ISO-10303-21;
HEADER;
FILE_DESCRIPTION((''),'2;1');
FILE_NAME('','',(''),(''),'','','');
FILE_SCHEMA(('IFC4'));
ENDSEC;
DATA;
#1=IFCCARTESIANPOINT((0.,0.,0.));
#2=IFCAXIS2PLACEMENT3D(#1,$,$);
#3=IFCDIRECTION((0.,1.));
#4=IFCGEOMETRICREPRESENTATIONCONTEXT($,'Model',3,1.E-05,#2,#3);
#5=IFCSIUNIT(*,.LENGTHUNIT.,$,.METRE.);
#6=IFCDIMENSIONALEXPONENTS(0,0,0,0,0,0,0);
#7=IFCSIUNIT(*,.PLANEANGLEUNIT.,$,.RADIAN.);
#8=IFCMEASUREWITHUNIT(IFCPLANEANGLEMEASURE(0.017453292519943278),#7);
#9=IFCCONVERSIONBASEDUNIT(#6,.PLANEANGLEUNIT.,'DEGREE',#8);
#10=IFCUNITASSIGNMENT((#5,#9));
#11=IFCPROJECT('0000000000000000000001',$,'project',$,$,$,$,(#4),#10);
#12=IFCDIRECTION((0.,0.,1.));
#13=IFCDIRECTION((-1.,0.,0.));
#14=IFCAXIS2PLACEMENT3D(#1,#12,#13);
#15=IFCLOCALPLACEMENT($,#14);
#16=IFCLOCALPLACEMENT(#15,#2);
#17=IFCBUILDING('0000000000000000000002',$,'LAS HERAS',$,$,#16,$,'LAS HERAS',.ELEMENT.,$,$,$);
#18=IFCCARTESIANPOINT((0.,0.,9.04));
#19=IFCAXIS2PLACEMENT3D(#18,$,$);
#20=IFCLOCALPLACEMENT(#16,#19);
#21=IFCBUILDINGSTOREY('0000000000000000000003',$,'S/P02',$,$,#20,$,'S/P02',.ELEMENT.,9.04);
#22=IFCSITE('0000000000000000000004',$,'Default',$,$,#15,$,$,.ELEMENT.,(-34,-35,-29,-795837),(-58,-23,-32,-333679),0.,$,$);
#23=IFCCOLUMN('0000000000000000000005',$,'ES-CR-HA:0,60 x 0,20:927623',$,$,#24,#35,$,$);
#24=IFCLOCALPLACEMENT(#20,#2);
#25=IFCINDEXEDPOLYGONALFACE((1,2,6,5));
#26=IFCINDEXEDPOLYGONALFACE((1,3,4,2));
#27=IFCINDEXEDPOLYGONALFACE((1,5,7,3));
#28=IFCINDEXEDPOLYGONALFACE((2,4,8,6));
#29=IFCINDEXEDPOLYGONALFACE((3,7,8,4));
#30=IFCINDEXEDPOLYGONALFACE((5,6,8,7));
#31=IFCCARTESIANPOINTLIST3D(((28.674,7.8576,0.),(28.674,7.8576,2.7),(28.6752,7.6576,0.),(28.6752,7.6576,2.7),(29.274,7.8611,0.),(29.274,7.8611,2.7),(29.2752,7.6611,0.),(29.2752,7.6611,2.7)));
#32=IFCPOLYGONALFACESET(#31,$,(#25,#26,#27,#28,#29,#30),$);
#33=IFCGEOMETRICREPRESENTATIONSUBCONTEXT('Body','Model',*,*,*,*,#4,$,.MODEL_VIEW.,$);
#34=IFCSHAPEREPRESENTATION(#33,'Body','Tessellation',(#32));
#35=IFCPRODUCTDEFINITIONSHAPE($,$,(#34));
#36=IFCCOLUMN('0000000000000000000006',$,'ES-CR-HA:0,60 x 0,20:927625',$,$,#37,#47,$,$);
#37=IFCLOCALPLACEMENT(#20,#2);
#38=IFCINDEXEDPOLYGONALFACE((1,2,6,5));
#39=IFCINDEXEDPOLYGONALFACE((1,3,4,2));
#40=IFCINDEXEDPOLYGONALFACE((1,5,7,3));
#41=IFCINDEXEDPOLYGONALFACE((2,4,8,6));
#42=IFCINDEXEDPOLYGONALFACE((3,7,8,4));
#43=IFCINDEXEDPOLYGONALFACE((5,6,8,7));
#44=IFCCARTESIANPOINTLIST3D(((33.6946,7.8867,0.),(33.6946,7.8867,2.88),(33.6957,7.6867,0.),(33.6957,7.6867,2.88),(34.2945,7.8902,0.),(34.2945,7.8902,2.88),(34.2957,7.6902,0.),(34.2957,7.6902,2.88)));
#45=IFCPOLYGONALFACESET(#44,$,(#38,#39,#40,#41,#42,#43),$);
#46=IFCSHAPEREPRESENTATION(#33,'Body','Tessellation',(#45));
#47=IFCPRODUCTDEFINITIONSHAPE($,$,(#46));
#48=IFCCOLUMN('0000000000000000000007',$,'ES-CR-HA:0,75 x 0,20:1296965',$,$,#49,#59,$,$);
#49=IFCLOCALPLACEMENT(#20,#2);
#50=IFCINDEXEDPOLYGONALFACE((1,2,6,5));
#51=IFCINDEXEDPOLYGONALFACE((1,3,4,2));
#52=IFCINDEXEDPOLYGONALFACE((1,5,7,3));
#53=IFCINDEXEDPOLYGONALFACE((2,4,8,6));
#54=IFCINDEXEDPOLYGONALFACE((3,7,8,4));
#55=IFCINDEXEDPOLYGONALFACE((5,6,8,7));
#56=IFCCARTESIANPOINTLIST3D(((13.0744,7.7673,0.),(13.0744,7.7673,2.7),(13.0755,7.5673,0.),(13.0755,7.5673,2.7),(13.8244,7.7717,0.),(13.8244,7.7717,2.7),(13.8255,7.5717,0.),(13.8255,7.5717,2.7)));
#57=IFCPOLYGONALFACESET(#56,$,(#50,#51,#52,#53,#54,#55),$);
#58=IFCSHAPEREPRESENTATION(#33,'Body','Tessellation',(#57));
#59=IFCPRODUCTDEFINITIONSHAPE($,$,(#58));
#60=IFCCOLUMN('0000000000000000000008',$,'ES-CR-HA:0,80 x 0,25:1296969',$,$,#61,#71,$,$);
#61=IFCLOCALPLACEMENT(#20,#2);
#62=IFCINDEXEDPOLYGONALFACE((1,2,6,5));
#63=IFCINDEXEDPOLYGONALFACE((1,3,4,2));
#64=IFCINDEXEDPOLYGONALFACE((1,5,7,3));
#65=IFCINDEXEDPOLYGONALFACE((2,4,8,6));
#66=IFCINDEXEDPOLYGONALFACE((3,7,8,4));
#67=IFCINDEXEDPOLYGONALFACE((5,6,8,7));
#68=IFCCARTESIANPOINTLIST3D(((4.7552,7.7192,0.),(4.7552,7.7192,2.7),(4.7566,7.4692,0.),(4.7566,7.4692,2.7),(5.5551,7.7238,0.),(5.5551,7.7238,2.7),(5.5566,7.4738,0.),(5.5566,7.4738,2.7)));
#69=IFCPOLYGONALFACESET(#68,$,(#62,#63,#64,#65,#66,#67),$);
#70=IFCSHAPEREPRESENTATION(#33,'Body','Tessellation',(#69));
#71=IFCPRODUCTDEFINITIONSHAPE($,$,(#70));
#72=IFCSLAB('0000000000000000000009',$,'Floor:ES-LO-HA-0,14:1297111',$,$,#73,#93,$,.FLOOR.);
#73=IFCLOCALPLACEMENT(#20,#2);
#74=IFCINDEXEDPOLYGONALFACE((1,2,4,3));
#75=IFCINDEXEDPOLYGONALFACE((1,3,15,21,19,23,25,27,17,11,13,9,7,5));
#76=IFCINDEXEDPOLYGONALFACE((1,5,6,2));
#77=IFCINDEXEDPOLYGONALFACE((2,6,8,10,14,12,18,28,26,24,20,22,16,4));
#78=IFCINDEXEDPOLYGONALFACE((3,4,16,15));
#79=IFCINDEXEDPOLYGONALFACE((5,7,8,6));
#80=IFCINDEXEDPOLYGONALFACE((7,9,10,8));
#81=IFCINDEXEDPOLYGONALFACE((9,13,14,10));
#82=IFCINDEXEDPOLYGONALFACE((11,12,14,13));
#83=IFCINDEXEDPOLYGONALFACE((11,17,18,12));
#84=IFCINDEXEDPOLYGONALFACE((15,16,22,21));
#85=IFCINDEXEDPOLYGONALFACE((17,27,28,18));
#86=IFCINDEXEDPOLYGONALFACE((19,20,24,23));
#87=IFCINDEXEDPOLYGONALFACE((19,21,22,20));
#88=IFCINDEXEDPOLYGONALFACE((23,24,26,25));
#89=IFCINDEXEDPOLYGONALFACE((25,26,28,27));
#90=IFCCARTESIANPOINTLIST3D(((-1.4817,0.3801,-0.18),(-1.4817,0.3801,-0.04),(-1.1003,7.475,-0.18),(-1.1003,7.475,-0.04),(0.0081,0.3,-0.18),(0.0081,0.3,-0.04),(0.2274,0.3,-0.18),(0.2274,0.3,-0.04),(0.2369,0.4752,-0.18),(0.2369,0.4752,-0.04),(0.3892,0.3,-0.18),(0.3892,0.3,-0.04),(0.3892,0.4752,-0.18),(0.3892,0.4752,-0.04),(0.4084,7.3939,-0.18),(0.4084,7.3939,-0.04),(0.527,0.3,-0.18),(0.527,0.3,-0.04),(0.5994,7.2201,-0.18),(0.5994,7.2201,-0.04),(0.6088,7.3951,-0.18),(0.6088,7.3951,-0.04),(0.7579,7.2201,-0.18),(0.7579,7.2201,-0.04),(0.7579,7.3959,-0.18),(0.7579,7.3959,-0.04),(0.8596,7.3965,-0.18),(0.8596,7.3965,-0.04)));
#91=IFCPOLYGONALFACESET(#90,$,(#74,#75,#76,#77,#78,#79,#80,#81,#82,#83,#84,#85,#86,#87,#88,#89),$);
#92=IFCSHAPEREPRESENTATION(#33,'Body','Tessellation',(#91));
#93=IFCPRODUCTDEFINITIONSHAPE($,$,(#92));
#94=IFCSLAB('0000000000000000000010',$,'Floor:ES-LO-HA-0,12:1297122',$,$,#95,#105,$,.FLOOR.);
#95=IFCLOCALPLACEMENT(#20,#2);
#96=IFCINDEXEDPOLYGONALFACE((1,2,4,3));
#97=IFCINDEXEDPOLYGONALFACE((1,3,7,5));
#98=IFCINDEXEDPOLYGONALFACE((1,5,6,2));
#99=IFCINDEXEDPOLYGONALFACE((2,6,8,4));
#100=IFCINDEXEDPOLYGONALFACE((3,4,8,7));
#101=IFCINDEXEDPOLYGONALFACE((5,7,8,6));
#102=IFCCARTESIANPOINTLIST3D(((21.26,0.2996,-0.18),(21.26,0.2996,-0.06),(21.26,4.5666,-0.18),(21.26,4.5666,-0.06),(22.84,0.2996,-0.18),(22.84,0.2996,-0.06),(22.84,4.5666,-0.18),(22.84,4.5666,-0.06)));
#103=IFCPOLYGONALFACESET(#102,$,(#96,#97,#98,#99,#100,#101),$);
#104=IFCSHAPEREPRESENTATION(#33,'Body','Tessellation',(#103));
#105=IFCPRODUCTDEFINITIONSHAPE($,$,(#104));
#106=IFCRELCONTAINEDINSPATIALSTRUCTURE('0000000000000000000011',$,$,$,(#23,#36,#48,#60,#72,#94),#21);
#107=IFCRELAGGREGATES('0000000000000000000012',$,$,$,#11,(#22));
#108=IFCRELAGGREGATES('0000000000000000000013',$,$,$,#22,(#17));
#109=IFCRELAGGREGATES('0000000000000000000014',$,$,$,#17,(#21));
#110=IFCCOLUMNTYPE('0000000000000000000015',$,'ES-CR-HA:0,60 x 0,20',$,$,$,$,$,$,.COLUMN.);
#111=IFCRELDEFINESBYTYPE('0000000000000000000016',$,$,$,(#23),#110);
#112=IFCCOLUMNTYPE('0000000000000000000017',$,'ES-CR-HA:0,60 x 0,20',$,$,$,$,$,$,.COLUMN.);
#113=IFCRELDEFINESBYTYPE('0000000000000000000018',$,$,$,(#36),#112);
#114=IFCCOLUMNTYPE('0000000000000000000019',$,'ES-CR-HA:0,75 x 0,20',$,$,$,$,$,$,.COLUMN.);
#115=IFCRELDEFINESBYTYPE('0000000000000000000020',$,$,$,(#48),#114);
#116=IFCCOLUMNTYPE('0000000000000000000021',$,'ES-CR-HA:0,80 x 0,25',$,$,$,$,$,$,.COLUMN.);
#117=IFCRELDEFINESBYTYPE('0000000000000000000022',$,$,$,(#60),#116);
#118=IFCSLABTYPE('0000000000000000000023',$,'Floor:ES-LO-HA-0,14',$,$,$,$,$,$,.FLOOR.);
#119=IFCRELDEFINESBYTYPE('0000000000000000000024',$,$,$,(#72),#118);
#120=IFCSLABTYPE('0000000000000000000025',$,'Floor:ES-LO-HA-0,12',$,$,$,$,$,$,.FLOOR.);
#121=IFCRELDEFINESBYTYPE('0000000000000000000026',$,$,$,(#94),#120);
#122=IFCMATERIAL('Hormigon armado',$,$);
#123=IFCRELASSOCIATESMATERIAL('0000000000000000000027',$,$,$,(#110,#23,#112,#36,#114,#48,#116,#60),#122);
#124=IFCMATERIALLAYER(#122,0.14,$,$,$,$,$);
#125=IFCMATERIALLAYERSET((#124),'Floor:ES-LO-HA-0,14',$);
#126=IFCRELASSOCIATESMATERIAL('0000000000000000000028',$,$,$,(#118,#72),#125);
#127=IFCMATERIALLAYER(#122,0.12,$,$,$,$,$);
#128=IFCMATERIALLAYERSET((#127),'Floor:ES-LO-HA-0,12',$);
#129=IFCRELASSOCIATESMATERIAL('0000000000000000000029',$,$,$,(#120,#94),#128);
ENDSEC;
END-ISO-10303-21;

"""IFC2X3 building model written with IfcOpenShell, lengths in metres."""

from ifc_helpers import new_model, entity, si_unit, converted_unit, direction, frame, frame_2d, origin, place, context, subcontext, project, spatial, polyline, rectangle, outline, extrude, source, transform, mapped, material, layer, layer_set, layer_usage, type_object, type_shapes, element, save


model = new_model("IFC2X3")

# Units and contexts
model_context = context("Model", 3, precision=1e-05, world=origin(), true_north=direction((0.0, 1.0)))
body_context = subcontext(model_context, "Body", "Model", "MODEL_VIEW")
ifc_project = project(units=[si_unit("LENGTHUNIT", "METRE"), converted_unit("PLANEANGLEUNIT", "DEGREE", entity("IfcPlaneAngleMeasure", 0.017453292519943278), si_unit("PLANEANGLEUNIT", "RADIAN"), dimensions=[0, 0, 0, 0, 0, 0, 0])], contexts=[model_context])

# Site, building, storey
site_placement = place(None, frame((0.0, 0.0, 0.0), z_axis=(0.0, 0.0, 1.0), x_axis=(-1.0, 0.0, 0.0)))
site = spatial("IfcSite", under=ifc_project, at=site_placement, Name="Default", CompositionType="ELEMENT", RefLatitude=(-34, -35, -29, -795837), RefLongitude=(-58, -23, -32, -333679), RefElevation=0.0)
building_placement = place(site_placement, origin())
building = spatial("IfcBuilding", under=site, at=building_placement, Name="LAS HERAS", LongName="LAS HERAS", CompositionType="ELEMENT")
storey_placement = place(building_placement, frame((0.0, 0.0, 9.04)))
storey = spatial("IfcBuildingStorey", under=building, at=storey_placement, Name="S/P02", LongName="S/P02", CompositionType="ELEMENT", Elevation=9.04)

# Columns
ifc_material = material(Name="Hormigon armado")
column_type_1 = type_object("IfcColumnType", Name="ES-CR-HA:0,60 x 0,20", PredefinedType="COLUMN", material=ifc_material)
shared_shape_1 = source(origin(), body_context, "Body", "SweptSolid", [
    extrude(rectangle(XDim=2.7, YDim=0.2, at=frame_2d((0.0, 0.0), x_axis=(1.0, 0.0))), frame((28.6746, 7.7576, 10.39), z_axis=(0.999983, 0.00576, 0.0), x_axis=(0.0, 0.0, 1.0)), (0.0, 0.0, 1.0), 0.6),
])
type_shapes(column_type_1, [shared_shape_1])
column_1_placement = place(storey_placement, frame((0.0, 0.0, -9.04)))
element("IfcColumn", 1, at=column_1_placement, inside=storey, type_object=column_type_1, material=ifc_material, Name="ES-CR-HA:0,60 x 0,20:927623", context=body_context, shape_type="MappedRepresentation", body=[
    mapped(shared_shape_1, transform((0.0, 0.0, 0.0), scale=1.0)),
])
column_type_2 = type_object("IfcColumnType", Name="ES-CR-HA:0,60 x 0,20", PredefinedType="COLUMN", material=ifc_material)
shared_shape_2 = source(origin(), body_context, "Body", "SweptSolid", [
    extrude(rectangle(XDim=0.6, YDim=0.2, at=frame_2d((0.0, 0.0), x_axis=(1.0, 0.0))), frame((33.9951, 7.7884, 9.04), z_axis=(0.0, 0.0, 1.0), x_axis=(-0.999983, -0.005788, 0.0)), (0.0, 0.0, 1.0), 2.88),
])
type_shapes(column_type_2, [shared_shape_2])
column_2_placement = place(storey_placement, frame((0.0, 0.0, -9.04)))
element("IfcColumn", 2, at=column_2_placement, inside=storey, type_object=column_type_2, material=ifc_material, Name="ES-CR-HA:0,60 x 0,20:927625", context=body_context, shape_type="MappedRepresentation", body=[
    mapped(shared_shape_2, transform((0.0, 0.0, 0.0), scale=1.0)),
])
column_type_3 = type_object("IfcColumnType", Name="ES-CR-HA:0,75 x 0,20", PredefinedType="COLUMN", material=ifc_material)
shared_shape_3 = source(origin(), body_context, "Body", "SweptSolid", [
    extrude(rectangle(XDim=0.75, YDim=0.2, at=frame_2d((0.0, 0.0), x_axis=(1.0, 0.0))), frame((13.4499, 7.6695, 9.04), z_axis=(0.0, 0.0, 1.0), x_axis=(-0.999983, -0.005788, 0.0)), (0.0, 0.0, 1.0), 2.7),
])
type_shapes(column_type_3, [shared_shape_3])
column_3_placement = place(storey_placement, frame((0.0, 0.0, -9.04)))
element("IfcColumn", 3, at=column_3_placement, inside=storey, type_object=column_type_3, material=ifc_material, Name="ES-CR-HA:0,75 x 0,20:1296965", context=body_context, shape_type="MappedRepresentation", body=[
    mapped(shared_shape_3, transform((0.0, 0.0, 0.0), scale=1.0)),
])
column_type_4 = type_object("IfcColumnType", Name="ES-CR-HA:0,80 x 0,25", PredefinedType="COLUMN", material=ifc_material)
shared_shape_4 = source(origin(), body_context, "Body", "SweptSolid", [
    extrude(rectangle(XDim=0.8, YDim=0.25, at=frame_2d((0.0, 0.0), x_axis=(1.0, 0.0))), frame((5.1559, 7.5965, 9.04), z_axis=(0.0, 0.0, 1.0), x_axis=(-0.999983, -0.005788, 0.0)), (0.0, 0.0, 1.0), 2.7),
])
type_shapes(column_type_4, [shared_shape_4])
column_4_placement = place(storey_placement, frame((0.0, 0.0, -9.04)))
element("IfcColumn", 4, at=column_4_placement, inside=storey, type_object=column_type_4, material=ifc_material, Name="ES-CR-HA:0,80 x 0,25:1296969", context=body_context, shape_type="MappedRepresentation", body=[
    mapped(shared_shape_4, transform((0.0, 0.0, 0.0), scale=1.0)),
])

# Slab, openings
ifc_layer_1 = layer(ifc_material, 0.14)
ifc_layer_set_1 = layer_set([ifc_layer_1], Name="Floor:ES-LO-HA-0,14")
ifc_layer_usage_1 = layer_usage(ifc_layer_set_1, "AXIS3", "POSITIVE", 0.0)
slab_type_1 = type_object("IfcSlabType", Name="Floor:ES-LO-HA-0,14", PredefinedType="FLOOR", material=ifc_layer_set_1)
slab_1_placement = place(storey_placement, origin())
slab_1 = element("IfcSlab", 5, at=slab_1_placement, inside=storey, type_object=slab_type_1, material=ifc_layer_usage_1, Name="Floor:ES-LO-HA-0,14:1297111", PredefinedType="FLOOR", context=body_context, shape_type="SweptSolid", body=[
    extrude(outline(polyline([(-0.2993, -3.5591), (-0.1615, -3.5591), (-0.1615, -3.3839), (-0.0091, -3.3839), (0.0003, -3.5591), (0.2196, -3.5591), (1.7094, -3.479), (1.328, 3.6159), (-0.1807, 3.5348), (-0.3811, 3.536), (-0.3717, 3.3611), (-0.5302, 3.3611), (-0.5302, 3.5368), (-0.6319, 3.5374), (-0.2993, -3.5591)])), frame((0.2277, 3.8591, -0.04), z_axis=(0.0, 0.0, -1.0), x_axis=(-1.0, 0.0, 0.0)), (0.0, 0.0, 1.0), 0.14),
])
opening_1_placement = place(slab_1_placement, origin())
element("IfcOpeningElement", 6, at=opening_1_placement, cuts=slab_1, ObjectType="Opening", context=body_context, shape_type="SweptSolid", body=[
    extrude(outline(polyline([(0.2369, 0.4752), (0.2274, 0.3), (0.3892, 0.3), (0.3892, 0.4752), (0.2369, 0.4752)])), frame((0.0, 0.0, -0.04)), (0.0, 0.0, -1.0), 0.14),
])
opening_2_placement = place(slab_1_placement, origin())
element("IfcOpeningElement", 7, at=opening_2_placement, cuts=slab_1, ObjectType="Opening", context=body_context, shape_type="SweptSolid", body=[
    extrude(outline(polyline([(0.7579, 7.2201), (0.7579, 7.3959), (0.6088, 7.3951), (0.5994, 7.2201), (0.7579, 7.2201)])), frame((0.0, 0.0, -0.04)), (0.0, 0.0, -1.0), 0.14),
])

# Slab
ifc_layer_2 = layer(ifc_material, 0.12)
ifc_layer_set_2 = layer_set([ifc_layer_2], Name="Floor:ES-LO-HA-0,12")
ifc_layer_usage_2 = layer_usage(ifc_layer_set_2, "AXIS3", "POSITIVE", 0.0)
slab_type_2 = type_object("IfcSlabType", Name="Floor:ES-LO-HA-0,12", PredefinedType="FLOOR", material=ifc_layer_set_2)
slab_2_placement = place(storey_placement, origin())
element("IfcSlab", 8, at=slab_2_placement, inside=storey, type_object=slab_type_2, material=ifc_layer_usage_2, Name="Floor:ES-LO-HA-0,12:1297122", PredefinedType="FLOOR", context=body_context, shape_type="SweptSolid", body=[
    extrude(rectangle(XDim=4.2671, YDim=1.58, at=frame_2d((0.0, 0.0), x_axis=(1.0, 0.0))), frame((22.05, 2.4331, -0.06), z_axis=(0.0, 0.0, -1.0), x_axis=(0.0, 1.0, 0.0)), (0.0, 0.0, 1.0), 0.12),
])

save(model, "model.ifc")
